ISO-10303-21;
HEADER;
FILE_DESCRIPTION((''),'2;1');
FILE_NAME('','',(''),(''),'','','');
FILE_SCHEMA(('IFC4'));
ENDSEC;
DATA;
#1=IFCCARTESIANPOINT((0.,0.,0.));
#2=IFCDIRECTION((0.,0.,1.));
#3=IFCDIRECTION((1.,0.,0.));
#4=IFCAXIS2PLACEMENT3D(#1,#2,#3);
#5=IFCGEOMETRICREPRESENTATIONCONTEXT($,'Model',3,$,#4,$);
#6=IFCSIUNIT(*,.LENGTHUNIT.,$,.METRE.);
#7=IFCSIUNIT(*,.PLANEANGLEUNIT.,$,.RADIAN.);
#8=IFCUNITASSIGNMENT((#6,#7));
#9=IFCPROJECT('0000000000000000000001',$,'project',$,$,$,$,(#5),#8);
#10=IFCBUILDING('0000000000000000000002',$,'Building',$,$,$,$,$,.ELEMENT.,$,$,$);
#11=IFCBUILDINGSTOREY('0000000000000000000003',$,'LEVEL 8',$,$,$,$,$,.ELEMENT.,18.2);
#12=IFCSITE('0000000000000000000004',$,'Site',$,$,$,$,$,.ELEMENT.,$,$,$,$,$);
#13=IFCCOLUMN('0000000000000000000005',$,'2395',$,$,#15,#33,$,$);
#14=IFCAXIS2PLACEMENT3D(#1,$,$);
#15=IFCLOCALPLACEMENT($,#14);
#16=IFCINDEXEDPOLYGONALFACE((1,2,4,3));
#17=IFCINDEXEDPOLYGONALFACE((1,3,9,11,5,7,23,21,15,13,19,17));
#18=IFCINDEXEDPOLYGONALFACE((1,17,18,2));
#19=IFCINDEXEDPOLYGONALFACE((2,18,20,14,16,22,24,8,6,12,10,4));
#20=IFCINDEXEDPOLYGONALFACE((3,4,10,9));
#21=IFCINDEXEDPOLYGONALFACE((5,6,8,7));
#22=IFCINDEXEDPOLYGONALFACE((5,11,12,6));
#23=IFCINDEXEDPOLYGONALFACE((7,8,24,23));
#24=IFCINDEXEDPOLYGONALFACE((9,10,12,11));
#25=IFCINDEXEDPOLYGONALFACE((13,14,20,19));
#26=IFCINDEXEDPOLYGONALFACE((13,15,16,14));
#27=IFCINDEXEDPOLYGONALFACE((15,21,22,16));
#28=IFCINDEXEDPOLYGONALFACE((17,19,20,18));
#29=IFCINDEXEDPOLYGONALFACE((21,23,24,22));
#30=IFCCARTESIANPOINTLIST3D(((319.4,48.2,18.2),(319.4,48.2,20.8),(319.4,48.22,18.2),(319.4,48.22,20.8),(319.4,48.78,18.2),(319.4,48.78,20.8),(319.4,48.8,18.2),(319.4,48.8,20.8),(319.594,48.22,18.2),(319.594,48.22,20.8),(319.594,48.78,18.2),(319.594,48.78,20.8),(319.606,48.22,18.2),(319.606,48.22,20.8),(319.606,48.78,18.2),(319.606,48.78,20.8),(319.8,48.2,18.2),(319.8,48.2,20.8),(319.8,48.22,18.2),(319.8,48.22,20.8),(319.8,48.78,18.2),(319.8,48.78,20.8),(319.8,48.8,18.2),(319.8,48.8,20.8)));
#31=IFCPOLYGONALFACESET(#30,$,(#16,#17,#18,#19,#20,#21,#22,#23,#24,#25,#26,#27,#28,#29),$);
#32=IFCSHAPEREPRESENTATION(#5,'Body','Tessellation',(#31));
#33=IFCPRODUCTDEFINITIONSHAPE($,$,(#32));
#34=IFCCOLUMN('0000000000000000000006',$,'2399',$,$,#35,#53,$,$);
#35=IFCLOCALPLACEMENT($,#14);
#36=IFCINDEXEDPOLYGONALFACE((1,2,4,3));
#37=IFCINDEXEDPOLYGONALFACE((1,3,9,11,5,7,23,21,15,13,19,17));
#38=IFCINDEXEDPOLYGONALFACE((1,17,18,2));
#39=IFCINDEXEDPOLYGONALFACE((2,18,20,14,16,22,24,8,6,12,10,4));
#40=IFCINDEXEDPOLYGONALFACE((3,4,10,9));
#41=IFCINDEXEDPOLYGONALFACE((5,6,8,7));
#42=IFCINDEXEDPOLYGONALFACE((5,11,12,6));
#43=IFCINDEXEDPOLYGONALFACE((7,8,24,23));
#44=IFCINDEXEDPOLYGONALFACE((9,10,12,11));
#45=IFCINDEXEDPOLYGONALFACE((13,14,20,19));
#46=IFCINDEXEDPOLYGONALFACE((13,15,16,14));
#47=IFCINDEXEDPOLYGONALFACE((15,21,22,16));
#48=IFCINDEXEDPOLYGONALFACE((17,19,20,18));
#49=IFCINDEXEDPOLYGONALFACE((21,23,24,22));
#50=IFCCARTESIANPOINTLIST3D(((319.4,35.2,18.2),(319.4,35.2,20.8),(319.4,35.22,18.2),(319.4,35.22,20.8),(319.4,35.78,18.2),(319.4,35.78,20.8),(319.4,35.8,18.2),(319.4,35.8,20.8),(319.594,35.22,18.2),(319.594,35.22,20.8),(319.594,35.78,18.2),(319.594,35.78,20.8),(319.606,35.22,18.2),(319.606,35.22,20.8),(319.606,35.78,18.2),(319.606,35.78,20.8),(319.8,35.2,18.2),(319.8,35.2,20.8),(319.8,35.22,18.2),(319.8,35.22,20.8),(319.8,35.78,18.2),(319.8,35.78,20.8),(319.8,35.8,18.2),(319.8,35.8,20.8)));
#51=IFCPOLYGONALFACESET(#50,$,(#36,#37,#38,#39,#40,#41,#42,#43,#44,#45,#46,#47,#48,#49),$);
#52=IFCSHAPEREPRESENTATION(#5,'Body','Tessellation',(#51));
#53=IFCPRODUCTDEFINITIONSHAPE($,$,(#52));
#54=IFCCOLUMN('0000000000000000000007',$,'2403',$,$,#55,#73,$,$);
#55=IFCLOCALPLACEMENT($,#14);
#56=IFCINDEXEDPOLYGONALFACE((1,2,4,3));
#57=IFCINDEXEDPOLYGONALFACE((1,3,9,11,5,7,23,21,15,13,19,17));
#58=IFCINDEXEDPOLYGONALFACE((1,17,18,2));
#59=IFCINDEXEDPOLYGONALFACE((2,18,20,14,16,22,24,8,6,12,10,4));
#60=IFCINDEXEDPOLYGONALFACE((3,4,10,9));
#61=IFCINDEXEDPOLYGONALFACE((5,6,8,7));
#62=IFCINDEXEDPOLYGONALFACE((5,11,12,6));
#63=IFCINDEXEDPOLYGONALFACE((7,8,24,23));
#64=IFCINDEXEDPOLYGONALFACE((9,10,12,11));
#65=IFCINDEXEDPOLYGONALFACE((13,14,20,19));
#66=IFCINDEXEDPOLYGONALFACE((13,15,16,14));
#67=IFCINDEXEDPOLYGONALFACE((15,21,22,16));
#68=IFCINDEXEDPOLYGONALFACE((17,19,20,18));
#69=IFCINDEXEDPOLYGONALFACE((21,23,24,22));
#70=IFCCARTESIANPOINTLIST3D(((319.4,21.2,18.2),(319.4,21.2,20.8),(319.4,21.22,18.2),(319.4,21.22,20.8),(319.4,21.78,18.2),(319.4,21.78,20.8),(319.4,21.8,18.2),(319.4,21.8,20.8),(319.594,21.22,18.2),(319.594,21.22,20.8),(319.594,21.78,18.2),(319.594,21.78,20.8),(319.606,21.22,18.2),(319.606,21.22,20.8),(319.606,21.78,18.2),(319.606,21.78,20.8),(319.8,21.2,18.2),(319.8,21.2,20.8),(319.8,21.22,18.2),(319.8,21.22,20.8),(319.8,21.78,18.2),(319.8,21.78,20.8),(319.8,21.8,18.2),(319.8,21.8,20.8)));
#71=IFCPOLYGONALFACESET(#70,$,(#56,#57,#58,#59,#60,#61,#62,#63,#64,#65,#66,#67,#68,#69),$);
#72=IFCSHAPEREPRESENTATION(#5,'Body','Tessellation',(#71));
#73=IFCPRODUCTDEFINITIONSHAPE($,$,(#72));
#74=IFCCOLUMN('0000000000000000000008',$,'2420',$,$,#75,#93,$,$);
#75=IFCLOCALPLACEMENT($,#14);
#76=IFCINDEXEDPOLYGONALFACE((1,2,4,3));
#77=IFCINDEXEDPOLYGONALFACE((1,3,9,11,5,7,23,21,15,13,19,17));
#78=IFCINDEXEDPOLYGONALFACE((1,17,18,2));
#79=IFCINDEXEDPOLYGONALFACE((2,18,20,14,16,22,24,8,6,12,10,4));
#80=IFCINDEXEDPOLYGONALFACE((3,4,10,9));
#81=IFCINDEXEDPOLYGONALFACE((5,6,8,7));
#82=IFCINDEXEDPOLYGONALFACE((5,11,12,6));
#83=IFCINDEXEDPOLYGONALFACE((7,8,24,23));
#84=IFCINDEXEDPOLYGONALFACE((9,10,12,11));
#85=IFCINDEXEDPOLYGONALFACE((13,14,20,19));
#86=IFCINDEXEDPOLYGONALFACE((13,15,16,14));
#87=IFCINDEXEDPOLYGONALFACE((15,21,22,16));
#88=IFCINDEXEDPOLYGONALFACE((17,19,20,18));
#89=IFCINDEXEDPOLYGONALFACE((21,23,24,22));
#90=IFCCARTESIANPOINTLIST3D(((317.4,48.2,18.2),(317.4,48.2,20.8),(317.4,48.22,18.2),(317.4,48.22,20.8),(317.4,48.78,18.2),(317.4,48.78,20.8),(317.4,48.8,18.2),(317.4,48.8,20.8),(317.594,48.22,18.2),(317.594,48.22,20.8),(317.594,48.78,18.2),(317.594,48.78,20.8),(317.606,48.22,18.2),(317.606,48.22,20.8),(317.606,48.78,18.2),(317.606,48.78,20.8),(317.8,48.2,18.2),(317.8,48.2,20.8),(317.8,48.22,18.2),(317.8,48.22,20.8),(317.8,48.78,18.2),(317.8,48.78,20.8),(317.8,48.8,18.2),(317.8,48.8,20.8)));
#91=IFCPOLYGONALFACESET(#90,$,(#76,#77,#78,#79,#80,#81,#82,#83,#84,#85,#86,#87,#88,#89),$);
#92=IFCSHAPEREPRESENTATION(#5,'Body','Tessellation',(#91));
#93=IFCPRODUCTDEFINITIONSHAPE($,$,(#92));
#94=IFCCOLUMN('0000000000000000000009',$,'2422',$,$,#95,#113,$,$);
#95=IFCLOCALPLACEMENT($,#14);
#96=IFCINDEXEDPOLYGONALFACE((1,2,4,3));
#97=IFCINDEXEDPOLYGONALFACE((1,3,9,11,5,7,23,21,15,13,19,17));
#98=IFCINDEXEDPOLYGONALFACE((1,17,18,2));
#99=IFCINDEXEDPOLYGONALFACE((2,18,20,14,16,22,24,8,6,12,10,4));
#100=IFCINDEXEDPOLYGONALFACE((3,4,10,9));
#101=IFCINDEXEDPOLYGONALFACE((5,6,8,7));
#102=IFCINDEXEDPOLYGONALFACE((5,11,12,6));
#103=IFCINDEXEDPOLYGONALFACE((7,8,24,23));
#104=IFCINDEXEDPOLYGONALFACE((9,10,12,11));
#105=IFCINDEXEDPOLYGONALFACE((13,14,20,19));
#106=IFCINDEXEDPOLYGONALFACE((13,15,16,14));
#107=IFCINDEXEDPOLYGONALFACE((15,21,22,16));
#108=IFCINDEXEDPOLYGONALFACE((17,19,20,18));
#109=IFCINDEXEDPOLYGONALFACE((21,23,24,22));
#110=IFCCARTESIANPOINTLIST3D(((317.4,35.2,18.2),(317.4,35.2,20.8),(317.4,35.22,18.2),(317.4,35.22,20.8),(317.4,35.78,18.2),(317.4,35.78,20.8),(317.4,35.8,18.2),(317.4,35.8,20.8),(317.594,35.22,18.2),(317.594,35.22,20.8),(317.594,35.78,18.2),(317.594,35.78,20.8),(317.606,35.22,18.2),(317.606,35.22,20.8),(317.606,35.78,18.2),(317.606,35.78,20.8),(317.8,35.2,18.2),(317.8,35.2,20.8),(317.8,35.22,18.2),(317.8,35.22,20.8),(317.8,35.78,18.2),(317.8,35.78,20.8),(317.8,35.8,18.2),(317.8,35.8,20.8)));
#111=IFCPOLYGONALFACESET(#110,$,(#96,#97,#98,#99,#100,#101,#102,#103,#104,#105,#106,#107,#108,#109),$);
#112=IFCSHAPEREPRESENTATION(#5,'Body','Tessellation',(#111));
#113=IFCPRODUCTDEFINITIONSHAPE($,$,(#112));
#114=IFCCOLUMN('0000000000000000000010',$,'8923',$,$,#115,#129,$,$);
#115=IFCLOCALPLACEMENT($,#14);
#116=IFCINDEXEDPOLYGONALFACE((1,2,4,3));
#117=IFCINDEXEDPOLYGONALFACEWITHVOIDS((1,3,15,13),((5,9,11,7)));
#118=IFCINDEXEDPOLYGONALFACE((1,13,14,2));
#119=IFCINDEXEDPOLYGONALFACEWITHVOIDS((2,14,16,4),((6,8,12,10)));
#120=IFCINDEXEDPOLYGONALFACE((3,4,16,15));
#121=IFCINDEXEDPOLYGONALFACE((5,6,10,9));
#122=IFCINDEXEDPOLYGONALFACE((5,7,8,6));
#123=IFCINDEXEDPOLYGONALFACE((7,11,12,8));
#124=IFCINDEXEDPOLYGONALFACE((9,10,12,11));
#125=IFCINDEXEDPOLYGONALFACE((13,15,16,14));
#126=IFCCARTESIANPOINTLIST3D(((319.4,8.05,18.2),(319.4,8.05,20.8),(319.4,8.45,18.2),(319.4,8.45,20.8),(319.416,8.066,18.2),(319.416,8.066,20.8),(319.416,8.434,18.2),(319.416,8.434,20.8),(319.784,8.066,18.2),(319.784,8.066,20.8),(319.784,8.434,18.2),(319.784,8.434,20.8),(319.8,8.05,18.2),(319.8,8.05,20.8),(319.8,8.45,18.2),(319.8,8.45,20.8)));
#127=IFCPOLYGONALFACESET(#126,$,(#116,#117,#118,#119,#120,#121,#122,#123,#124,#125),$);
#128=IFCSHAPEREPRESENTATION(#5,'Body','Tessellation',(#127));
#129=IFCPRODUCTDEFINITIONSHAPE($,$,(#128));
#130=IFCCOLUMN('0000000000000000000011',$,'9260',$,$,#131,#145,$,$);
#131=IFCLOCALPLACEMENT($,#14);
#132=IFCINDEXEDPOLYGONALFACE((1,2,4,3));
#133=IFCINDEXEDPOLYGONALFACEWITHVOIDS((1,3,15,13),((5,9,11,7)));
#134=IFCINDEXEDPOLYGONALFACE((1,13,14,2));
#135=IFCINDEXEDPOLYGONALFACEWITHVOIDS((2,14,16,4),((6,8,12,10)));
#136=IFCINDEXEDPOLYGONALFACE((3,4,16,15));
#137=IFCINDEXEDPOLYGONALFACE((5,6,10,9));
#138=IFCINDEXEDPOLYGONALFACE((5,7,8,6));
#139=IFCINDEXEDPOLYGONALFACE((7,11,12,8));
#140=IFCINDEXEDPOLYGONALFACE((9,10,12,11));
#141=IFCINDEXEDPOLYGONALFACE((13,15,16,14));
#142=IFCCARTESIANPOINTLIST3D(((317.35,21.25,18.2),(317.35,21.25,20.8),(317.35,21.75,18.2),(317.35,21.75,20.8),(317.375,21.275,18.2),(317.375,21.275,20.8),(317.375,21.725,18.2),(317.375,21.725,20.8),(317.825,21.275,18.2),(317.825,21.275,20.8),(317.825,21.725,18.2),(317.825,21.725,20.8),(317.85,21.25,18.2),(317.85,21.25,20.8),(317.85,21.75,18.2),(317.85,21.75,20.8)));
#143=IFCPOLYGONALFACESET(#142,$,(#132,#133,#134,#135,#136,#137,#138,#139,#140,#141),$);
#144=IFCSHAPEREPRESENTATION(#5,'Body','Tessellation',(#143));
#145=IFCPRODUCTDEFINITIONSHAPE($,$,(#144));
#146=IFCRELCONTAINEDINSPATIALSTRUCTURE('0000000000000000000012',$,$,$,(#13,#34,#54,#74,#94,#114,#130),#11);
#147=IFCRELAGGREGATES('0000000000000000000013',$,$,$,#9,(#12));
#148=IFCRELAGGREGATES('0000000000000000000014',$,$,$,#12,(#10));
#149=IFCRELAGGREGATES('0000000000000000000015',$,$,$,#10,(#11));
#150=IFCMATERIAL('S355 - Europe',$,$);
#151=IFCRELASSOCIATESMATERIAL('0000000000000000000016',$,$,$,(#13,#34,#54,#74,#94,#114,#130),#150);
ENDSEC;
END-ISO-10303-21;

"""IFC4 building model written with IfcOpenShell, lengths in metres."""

from ifc_helpers import new_model, si_unit, frame, origin_with_axes, origin_2d_with_axis, place, context, project, spatial, hollow_rectangle, i_section, extrude, material, material_profile, profile_set, profile_usage, element, save


model = new_model("IFC4")

# Units and contexts
model_context = context("Model", 3, world=origin_with_axes())
ifc_project = project(units=[si_unit("LENGTHUNIT", "METRE"), si_unit("PLANEANGLEUNIT", "RADIAN")], contexts=[model_context])

# Site, building, storey
site = spatial("IfcSite", under=ifc_project, Name="Site", CompositionType="ELEMENT")
building = spatial("IfcBuilding", under=site, Name="Building", CompositionType="ELEMENT")
storey = spatial("IfcBuildingStorey", under=building, Name="LEVEL 8", CompositionType="ELEMENT", Elevation=18.2)

# Columns
ifc_material = material(Name="S355 - Europe")
ifc_material_profile_1 = material_profile(ifc_material, i_section(OverallWidth=0.4, OverallDepth=0.6, WebThickness=0.012, FlangeThickness=0.02, at=origin_2d_with_axis()))
ifc_profile_set_1 = profile_set([ifc_material_profile_1])
ifc_profile_usage_1 = profile_usage(ifc_profile_set_1, cardinal=10)
column_1_placement = place(None, frame((319.6, 48.5, 18.2), z_axis=(0.0, 0.0, 1.0), x_axis=(1.0, 0.0, 0.0)))
element("IfcColumn", 1, at=column_1_placement, inside=storey, material=ifc_profile_usage_1, Name="2395", context=model_context, shape_type="SweptSolid", body=[
    extrude(i_section(OverallWidth=0.4, OverallDepth=0.6, WebThickness=0.012, FlangeThickness=0.02, at=origin_2d_with_axis()), origin_with_axes(), (0.0, 0.0, 1.0), 2.6),
])
ifc_material_profile_2 = material_profile(ifc_material, i_section(OverallWidth=0.4, OverallDepth=0.6, WebThickness=0.012, FlangeThickness=0.02, at=origin_2d_with_axis()))
ifc_profile_set_2 = profile_set([ifc_material_profile_2])
ifc_profile_usage_2 = profile_usage(ifc_profile_set_2, cardinal=10)
column_2_placement = place(None, frame((319.6, 35.5, 18.2), z_axis=(0.0, 0.0, 1.0), x_axis=(1.0, 0.0, 0.0)))
element("IfcColumn", 2, at=column_2_placement, inside=storey, material=ifc_profile_usage_2, Name="2399", context=model_context, shape_type="SweptSolid", body=[
    extrude(i_section(OverallWidth=0.4, OverallDepth=0.6, WebThickness=0.012, FlangeThickness=0.02, at=origin_2d_with_axis()), origin_with_axes(), (0.0, 0.0, 1.0), 2.6),
])
ifc_material_profile_3 = material_profile(ifc_material, i_section(OverallWidth=0.4, OverallDepth=0.6, WebThickness=0.012, FlangeThickness=0.02, at=origin_2d_with_axis()))
ifc_profile_set_3 = profile_set([ifc_material_profile_3])
ifc_profile_usage_3 = profile_usage(ifc_profile_set_3, cardinal=10)
column_3_placement = place(None, frame((319.6, 21.5, 18.2), z_axis=(0.0, 0.0, 1.0), x_axis=(1.0, 0.0, 0.0)))
element("IfcColumn", 3, at=column_3_placement, inside=storey, material=ifc_profile_usage_3, Name="2403", context=model_context, shape_type="SweptSolid", body=[
    extrude(i_section(OverallWidth=0.4, OverallDepth=0.6, WebThickness=0.012, FlangeThickness=0.02, at=origin_2d_with_axis()), origin_with_axes(), (0.0, 0.0, 1.0), 2.6),
])
ifc_material_profile_4 = material_profile(ifc_material, i_section(OverallWidth=0.4, OverallDepth=0.6, WebThickness=0.012, FlangeThickness=0.02, at=origin_2d_with_axis()))
ifc_profile_set_4 = profile_set([ifc_material_profile_4])
ifc_profile_usage_4 = profile_usage(ifc_profile_set_4, cardinal=10)
column_4_placement = place(None, frame((317.6, 48.5, 18.2), z_axis=(0.0, 0.0, 1.0), x_axis=(1.0, 0.0, 0.0)))
element("IfcColumn", 4, at=column_4_placement, inside=storey, material=ifc_profile_usage_4, Name="2420", context=model_context, shape_type="SweptSolid", body=[
    extrude(i_section(OverallWidth=0.4, OverallDepth=0.6, WebThickness=0.012, FlangeThickness=0.02, at=origin_2d_with_axis()), origin_with_axes(), (0.0, 0.0, 1.0), 2.6),
])
ifc_material_profile_5 = material_profile(ifc_material, i_section(OverallWidth=0.4, OverallDepth=0.6, WebThickness=0.012, FlangeThickness=0.02, at=origin_2d_with_axis()))
ifc_profile_set_5 = profile_set([ifc_material_profile_5])
ifc_profile_usage_5 = profile_usage(ifc_profile_set_5, cardinal=10)
column_5_placement = place(None, frame((317.6, 35.5, 18.2), z_axis=(0.0, 0.0, 1.0), x_axis=(1.0, 0.0, 0.0)))
element("IfcColumn", 5, at=column_5_placement, inside=storey, material=ifc_profile_usage_5, Name="2422", context=model_context, shape_type="SweptSolid", body=[
    extrude(i_section(OverallWidth=0.4, OverallDepth=0.6, WebThickness=0.012, FlangeThickness=0.02, at=origin_2d_with_axis()), origin_with_axes(), (0.0, 0.0, 1.0), 2.6),
])
ifc_material_profile_6 = material_profile(ifc_material, hollow_rectangle(XDim=0.4, YDim=0.4, WallThickness=0.016, at=origin_2d_with_axis()))
ifc_profile_set_6 = profile_set([ifc_material_profile_6])
ifc_profile_usage_6 = profile_usage(ifc_profile_set_6, cardinal=10)
column_6_placement = place(None, frame((319.6, 8.25, 18.2), z_axis=(0.0, 0.0, 1.0), x_axis=(0.0, -1.0, 0.0)))
element("IfcColumn", 6, at=column_6_placement, inside=storey, material=ifc_profile_usage_6, Name="8923", context=model_context, shape_type="SweptSolid", body=[
    extrude(hollow_rectangle(XDim=0.4, YDim=0.4, WallThickness=0.016, at=origin_2d_with_axis()), origin_with_axes(), (0.0, 0.0, 1.0), 2.6),
])
ifc_material_profile_7 = material_profile(ifc_material, hollow_rectangle(XDim=0.5, YDim=0.5, WallThickness=0.025, at=origin_2d_with_axis()))
ifc_profile_set_7 = profile_set([ifc_material_profile_7])
ifc_profile_usage_7 = profile_usage(ifc_profile_set_7, cardinal=10)
column_7_placement = place(None, frame((317.6, 21.5, 18.2), z_axis=(0.0, 0.0, 1.0), x_axis=(1.0, 0.0, 0.0)))
element("IfcColumn", 7, at=column_7_placement, inside=storey, material=ifc_profile_usage_7, Name="9260", context=model_context, shape_type="SweptSolid", body=[
    extrude(hollow_rectangle(XDim=0.5, YDim=0.5, WallThickness=0.025, at=origin_2d_with_axis()), origin_with_axes(), (0.0, 0.0, 1.0), 2.6),
])

save(model, "model.ifc")
